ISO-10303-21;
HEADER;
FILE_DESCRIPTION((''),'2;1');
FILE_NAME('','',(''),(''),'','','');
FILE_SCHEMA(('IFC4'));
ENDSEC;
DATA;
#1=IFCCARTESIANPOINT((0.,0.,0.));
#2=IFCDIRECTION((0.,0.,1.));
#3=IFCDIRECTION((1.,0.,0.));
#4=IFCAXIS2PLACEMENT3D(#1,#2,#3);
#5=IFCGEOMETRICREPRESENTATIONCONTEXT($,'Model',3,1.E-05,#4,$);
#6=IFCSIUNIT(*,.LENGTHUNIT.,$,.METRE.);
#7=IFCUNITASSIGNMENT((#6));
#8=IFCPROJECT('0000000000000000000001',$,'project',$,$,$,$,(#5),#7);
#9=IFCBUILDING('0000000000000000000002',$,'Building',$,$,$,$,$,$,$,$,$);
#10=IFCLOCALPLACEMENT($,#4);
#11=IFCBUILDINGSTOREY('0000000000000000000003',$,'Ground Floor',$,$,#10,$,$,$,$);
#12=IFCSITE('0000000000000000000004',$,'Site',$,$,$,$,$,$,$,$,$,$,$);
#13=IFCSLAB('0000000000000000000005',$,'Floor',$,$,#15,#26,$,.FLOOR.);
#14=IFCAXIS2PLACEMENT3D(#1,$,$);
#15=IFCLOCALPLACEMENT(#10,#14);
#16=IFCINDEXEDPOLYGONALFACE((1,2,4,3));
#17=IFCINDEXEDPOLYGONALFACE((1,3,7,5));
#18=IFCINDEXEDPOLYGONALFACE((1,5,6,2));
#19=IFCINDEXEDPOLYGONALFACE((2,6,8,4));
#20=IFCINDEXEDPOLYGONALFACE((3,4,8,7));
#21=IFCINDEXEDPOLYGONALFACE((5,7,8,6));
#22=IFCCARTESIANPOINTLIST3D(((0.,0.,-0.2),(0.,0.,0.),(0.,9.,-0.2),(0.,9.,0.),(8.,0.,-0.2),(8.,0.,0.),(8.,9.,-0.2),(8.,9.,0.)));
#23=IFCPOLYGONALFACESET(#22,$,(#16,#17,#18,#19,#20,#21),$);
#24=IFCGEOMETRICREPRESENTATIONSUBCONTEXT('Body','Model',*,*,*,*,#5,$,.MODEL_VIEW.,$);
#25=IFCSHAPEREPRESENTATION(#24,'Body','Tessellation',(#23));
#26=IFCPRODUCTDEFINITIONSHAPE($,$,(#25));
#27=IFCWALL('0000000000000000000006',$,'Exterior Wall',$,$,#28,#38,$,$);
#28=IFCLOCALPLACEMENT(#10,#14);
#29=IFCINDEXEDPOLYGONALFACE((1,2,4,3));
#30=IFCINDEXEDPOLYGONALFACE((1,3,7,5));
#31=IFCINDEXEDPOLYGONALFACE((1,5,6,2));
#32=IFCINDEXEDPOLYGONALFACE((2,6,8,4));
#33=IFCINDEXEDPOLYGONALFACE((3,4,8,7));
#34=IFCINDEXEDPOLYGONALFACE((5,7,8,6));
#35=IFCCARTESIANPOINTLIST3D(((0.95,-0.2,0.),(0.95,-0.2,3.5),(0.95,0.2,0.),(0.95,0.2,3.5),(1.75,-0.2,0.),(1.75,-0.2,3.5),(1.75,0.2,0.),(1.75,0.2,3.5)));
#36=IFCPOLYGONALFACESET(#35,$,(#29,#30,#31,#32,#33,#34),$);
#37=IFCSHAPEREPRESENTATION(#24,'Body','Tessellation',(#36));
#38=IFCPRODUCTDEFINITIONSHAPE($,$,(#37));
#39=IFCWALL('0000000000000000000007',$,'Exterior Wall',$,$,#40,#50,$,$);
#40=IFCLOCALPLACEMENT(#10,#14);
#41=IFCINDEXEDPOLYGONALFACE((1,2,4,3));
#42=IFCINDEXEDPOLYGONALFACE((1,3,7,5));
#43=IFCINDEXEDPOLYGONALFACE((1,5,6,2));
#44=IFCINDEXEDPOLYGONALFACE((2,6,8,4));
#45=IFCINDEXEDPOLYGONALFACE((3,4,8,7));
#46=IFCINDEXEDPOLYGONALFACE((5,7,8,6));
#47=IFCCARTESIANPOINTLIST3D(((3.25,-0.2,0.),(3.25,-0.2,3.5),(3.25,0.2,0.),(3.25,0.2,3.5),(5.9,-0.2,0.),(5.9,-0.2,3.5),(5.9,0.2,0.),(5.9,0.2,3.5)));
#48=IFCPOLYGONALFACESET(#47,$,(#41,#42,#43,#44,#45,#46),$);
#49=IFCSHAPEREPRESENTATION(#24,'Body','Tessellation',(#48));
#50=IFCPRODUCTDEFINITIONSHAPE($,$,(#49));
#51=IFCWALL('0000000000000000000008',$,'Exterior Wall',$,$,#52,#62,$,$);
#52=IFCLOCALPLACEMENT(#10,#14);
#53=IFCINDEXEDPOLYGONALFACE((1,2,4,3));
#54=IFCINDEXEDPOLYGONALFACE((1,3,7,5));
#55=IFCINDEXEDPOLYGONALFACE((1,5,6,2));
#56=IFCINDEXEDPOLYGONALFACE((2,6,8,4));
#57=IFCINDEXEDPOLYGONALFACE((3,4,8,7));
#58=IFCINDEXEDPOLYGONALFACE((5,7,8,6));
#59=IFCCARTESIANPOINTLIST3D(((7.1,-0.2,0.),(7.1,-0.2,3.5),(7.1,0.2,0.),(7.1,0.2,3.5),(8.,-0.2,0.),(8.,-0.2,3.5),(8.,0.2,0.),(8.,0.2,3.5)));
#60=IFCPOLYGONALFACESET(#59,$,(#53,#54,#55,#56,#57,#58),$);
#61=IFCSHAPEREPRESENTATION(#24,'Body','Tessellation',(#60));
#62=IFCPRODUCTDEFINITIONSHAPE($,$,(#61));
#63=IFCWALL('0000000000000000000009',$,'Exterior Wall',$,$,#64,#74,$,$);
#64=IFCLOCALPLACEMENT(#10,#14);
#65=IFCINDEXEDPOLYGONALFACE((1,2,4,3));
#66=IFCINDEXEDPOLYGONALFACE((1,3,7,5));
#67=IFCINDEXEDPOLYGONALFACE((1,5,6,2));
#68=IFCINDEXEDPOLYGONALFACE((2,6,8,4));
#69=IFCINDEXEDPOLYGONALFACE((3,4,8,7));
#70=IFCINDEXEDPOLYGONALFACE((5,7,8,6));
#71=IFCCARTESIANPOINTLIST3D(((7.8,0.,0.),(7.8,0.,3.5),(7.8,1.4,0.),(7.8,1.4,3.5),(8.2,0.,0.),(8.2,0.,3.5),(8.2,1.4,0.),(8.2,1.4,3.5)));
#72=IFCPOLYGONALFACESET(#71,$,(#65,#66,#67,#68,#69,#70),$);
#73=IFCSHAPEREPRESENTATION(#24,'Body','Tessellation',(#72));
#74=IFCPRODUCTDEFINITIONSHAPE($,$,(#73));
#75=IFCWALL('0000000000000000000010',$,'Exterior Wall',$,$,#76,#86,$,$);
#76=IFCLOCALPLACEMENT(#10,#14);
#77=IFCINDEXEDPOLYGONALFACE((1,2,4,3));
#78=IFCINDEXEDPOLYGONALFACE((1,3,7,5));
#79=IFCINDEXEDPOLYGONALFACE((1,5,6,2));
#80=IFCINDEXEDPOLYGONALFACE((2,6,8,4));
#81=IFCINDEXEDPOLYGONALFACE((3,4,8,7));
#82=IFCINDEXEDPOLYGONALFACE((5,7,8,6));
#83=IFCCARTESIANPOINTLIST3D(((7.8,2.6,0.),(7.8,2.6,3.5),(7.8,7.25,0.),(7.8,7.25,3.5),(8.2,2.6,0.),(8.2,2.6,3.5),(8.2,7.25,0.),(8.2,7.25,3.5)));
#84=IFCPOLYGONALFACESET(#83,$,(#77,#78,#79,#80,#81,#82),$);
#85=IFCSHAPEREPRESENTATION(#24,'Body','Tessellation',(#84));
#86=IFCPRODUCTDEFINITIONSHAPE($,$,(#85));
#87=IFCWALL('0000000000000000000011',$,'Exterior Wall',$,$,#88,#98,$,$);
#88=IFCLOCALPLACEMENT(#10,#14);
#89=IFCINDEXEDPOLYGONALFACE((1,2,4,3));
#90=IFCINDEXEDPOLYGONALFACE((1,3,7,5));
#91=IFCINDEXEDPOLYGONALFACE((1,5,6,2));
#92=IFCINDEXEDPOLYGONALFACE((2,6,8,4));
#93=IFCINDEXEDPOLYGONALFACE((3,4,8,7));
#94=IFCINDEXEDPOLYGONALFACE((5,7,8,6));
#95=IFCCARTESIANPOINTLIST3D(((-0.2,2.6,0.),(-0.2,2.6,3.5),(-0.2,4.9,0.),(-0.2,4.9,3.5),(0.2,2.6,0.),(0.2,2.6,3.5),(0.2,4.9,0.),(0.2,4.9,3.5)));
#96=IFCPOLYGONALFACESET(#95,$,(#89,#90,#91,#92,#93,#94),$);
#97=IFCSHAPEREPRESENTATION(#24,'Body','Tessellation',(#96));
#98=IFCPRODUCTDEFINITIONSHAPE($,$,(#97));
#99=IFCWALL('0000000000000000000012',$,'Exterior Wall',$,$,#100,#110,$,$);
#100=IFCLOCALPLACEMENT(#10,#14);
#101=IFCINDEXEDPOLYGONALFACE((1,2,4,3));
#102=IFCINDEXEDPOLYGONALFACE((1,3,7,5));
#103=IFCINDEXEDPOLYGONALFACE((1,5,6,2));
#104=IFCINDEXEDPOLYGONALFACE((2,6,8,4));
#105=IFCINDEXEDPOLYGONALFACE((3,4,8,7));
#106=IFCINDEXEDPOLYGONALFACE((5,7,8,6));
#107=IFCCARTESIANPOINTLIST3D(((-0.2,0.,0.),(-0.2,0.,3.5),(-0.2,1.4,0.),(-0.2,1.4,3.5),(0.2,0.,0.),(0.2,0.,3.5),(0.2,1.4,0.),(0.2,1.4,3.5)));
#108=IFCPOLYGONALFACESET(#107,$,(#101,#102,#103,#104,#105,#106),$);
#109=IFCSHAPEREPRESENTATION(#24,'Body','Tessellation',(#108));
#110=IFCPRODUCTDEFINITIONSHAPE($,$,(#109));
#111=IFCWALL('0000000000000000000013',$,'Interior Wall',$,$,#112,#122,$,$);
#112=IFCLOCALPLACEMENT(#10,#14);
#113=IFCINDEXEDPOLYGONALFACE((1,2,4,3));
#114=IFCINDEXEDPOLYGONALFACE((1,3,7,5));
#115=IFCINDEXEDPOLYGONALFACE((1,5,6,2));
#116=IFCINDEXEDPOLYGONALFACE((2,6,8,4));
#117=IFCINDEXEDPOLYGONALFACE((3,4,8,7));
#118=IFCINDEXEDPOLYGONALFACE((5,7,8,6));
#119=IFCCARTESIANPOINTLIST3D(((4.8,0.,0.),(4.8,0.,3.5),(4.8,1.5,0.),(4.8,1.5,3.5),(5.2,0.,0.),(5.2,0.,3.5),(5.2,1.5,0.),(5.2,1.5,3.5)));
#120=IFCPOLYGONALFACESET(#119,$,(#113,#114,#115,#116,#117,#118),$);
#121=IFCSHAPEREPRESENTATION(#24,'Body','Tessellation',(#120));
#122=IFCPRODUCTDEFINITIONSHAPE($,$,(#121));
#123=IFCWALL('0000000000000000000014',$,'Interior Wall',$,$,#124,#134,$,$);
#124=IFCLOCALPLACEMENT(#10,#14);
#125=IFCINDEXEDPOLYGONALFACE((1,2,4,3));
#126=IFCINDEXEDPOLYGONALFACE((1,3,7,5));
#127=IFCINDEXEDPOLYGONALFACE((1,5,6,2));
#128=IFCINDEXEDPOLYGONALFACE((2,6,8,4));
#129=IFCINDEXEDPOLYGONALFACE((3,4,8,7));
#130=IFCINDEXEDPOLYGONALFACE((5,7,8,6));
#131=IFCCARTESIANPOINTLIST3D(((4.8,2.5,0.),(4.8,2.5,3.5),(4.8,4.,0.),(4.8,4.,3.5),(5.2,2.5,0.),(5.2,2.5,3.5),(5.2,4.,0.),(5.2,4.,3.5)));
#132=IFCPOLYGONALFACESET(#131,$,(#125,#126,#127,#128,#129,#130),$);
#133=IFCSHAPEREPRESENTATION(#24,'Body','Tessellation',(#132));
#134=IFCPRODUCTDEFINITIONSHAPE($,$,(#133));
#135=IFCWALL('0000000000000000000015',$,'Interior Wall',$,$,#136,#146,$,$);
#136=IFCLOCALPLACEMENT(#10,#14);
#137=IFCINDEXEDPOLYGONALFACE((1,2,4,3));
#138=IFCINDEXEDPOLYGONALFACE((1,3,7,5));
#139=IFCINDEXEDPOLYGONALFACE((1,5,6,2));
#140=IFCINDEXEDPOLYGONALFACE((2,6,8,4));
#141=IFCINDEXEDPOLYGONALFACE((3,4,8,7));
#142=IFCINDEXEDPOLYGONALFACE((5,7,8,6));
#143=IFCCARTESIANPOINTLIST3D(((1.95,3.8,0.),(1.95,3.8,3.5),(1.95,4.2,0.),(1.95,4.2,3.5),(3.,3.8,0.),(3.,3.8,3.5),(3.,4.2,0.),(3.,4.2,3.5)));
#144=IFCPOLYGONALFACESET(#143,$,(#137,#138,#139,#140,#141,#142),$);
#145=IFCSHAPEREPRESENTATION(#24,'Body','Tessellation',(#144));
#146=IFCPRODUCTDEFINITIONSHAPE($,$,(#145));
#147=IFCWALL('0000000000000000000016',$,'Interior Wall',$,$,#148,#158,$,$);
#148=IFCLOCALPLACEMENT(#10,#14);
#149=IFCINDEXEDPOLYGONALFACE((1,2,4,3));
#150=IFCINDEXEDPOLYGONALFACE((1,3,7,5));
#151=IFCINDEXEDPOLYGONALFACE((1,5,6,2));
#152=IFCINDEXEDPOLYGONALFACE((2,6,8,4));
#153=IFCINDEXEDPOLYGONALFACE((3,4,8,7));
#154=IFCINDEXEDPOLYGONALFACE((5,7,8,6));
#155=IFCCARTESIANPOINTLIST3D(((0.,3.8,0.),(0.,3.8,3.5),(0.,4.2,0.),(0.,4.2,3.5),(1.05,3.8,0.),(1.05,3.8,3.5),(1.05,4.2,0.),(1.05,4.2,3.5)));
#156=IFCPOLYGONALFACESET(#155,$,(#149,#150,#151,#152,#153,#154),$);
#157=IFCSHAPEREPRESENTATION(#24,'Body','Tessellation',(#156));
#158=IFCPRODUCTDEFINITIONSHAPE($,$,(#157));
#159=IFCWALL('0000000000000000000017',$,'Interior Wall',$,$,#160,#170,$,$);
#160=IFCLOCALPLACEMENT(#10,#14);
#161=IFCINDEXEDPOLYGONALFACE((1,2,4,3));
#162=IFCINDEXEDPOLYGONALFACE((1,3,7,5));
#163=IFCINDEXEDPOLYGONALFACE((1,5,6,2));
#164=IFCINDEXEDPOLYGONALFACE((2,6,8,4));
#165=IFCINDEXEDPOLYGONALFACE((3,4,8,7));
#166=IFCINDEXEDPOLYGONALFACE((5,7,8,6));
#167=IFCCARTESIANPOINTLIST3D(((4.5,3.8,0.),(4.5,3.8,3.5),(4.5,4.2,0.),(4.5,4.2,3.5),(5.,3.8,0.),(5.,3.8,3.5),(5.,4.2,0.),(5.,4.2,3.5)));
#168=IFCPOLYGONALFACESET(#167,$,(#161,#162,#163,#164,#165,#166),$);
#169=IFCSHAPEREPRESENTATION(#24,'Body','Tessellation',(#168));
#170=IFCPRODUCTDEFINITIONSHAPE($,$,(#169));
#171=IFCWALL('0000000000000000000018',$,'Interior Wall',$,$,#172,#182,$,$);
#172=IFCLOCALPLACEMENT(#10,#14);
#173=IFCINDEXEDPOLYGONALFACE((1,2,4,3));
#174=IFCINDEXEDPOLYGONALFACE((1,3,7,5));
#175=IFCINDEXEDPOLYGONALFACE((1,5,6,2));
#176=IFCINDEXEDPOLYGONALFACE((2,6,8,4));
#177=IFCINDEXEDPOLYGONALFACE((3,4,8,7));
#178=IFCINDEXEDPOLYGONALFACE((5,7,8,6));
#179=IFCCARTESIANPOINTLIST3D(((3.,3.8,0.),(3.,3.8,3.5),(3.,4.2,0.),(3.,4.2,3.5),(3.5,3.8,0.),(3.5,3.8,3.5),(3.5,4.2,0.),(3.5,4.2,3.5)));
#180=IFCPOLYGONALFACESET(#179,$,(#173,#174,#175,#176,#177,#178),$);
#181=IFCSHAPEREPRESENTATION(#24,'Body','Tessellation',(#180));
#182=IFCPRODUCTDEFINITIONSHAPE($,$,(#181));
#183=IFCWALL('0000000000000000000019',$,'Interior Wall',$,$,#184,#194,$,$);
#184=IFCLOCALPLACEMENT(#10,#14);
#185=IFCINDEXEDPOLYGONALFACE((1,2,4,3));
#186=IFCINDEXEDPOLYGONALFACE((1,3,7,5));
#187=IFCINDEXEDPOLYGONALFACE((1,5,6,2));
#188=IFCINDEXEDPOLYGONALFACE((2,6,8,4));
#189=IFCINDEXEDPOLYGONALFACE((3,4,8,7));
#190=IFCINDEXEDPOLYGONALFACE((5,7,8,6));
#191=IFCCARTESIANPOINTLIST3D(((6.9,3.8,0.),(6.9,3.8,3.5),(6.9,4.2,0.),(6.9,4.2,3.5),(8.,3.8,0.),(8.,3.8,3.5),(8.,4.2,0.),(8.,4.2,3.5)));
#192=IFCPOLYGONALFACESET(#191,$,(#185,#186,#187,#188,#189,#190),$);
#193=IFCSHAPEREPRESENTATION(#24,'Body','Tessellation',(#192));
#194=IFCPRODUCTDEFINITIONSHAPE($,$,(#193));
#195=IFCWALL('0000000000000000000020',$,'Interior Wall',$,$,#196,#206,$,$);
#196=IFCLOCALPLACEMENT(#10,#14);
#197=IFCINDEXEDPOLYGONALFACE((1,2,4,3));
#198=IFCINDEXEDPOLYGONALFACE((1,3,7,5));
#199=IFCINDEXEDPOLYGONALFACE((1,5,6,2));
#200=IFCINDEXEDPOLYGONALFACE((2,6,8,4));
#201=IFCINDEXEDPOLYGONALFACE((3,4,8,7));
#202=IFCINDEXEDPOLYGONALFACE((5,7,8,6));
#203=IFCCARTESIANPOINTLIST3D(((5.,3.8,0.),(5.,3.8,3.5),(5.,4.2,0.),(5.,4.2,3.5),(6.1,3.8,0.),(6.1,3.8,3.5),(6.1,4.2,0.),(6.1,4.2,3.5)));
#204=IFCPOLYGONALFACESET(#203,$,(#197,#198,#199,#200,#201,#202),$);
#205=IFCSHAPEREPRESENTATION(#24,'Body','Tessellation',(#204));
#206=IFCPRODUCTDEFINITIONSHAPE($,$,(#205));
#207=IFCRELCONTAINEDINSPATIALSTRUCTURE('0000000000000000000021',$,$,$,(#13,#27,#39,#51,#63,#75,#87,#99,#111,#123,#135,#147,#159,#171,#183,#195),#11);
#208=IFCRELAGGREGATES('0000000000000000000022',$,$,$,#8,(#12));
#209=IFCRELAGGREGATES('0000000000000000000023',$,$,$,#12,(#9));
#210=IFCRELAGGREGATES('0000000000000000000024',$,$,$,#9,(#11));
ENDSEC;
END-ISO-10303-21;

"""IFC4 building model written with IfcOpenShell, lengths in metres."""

from ifc_helpers import new_model, si_unit, frame, origin_with_axes, place, context, subcontext, project, spatial, indexed_curve, outline, extrude, element, save


model = new_model("IFC4")

# Units and contexts
model_context = context("Model", 3, precision=1e-05, world=origin_with_axes())
body_context = subcontext(model_context, "Body", "Model", "MODEL_VIEW")
ifc_project = project(units=[si_unit("LENGTHUNIT", "METRE")], contexts=[model_context])

# Site, building, storey
site = spatial("IfcSite", under=ifc_project, Name="Site")
building = spatial("IfcBuilding", under=site, Name="Building")
storey_placement = place(None, origin_with_axes())
storey = spatial("IfcBuildingStorey", under=building, at=storey_placement, Name="Ground Floor")

# Slab
slab_placement = place(storey_placement, frame((0.0, 0.0, -0.2), z_axis=(0.0, 0.0, 1.0), x_axis=(1.0, 0.0, 0.0)))
element("IfcSlab", 1, at=slab_placement, inside=storey, Name="Floor", PredefinedType="FLOOR", context=body_context, shape_type="SweptSolid", body=[
    extrude(outline(indexed_curve([(0.0, 0.0), (8.0, 0.0), (8.0, 9.0), (0.0, 9.0)])), None, (0.0, 0.0, 1.0), 0.2),
])

# Walls
wall_1_placement = place(storey_placement, frame((0.95, 0.0, 0.0), z_axis=(0.0, 0.0, 1.0), x_axis=(1.0, 0.0, 0.0)))
element("IfcWall", 2, at=wall_1_placement, inside=storey, Name="Exterior Wall", context=body_context, shape_type="SweptSolid", body=[
    extrude(outline(indexed_curve([(0.0, 0.0), (0.0, 0.4), (0.8, 0.4), (0.8, 0.0), (0.0, 0.0)], self_intersect=False)), frame((0.0, -0.2, 0.0), z_axis=(0.0, 0.0, 1.0), x_axis=(1.0, 0.0, 0.0)), (0.0, 0.0, 1.0), 3.5),
])
wall_2_placement = place(storey_placement, frame((3.25, 0.0, 0.0), z_axis=(0.0, 0.0, 1.0), x_axis=(1.0, 0.0, 0.0)))
element("IfcWall", 3, at=wall_2_placement, inside=storey, Name="Exterior Wall", context=body_context, shape_type="SweptSolid", body=[
    extrude(outline(indexed_curve([(0.0, 0.0), (0.0, 0.4), (2.65, 0.4), (2.65, 0.0), (0.0, 0.0)], self_intersect=False)), frame((0.0, -0.2, 0.0), z_axis=(0.0, 0.0, 1.0), x_axis=(1.0, 0.0, 0.0)), (0.0, 0.0, 1.0), 3.5),
])
wall_3_placement = place(storey_placement, frame((7.1, 0.0, 0.0), z_axis=(0.0, 0.0, 1.0), x_axis=(1.0, 0.0, 0.0)))
element("IfcWall", 4, at=wall_3_placement, inside=storey, Name="Exterior Wall", context=body_context, shape_type="SweptSolid", body=[
    extrude(outline(indexed_curve([(0.0, 0.0), (0.0, 0.4), (0.9, 0.4), (0.9, 0.0), (0.0, 0.0)], self_intersect=False)), frame((0.0, -0.2, 0.0), z_axis=(0.0, 0.0, 1.0), x_axis=(1.0, 0.0, 0.0)), (0.0, 0.0, 1.0), 3.5),
])
wall_4_placement = place(storey_placement, frame((8.0, 0.0, 0.0), z_axis=(0.0, 0.0, 1.0), x_axis=(0.0, 1.0, 0.0)))
element("IfcWall", 5, at=wall_4_placement, inside=storey, Name="Exterior Wall", context=body_context, shape_type="SweptSolid", body=[
    extrude(outline(indexed_curve([(0.0, 0.0), (0.0, 0.4), (1.4, 0.4), (1.4, 0.0), (0.0, 0.0)], self_intersect=False)), frame((0.0, -0.2, 0.0), z_axis=(0.0, 0.0, 1.0), x_axis=(1.0, 0.0, 0.0)), (0.0, 0.0, 1.0), 3.5),
])
wall_5_placement = place(storey_placement, frame((8.0, 2.6, 0.0), z_axis=(0.0, 0.0, 1.0), x_axis=(0.0, 1.0, 0.0)))
element("IfcWall", 6, at=wall_5_placement, inside=storey, Name="Exterior Wall", context=body_context, shape_type="SweptSolid", body=[
    extrude(outline(indexed_curve([(0.0, 0.0), (0.0, 0.4), (4.65, 0.4), (4.65, 0.0), (0.0, 0.0)], self_intersect=False)), frame((0.0, -0.2, 0.0), z_axis=(0.0, 0.0, 1.0), x_axis=(1.0, 0.0, 0.0)), (0.0, 0.0, 1.0), 3.5),
])
wall_6_placement = place(storey_placement, frame((0.0, 4.9, 0.0), z_axis=(0.0, 0.0, 1.0), x_axis=(0.0, -1.0, 0.0)))
element("IfcWall", 7, at=wall_6_placement, inside=storey, Name="Exterior Wall", context=body_context, shape_type="SweptSolid", body=[
    extrude(outline(indexed_curve([(0.0, 0.0), (0.0, 0.4), (2.3, 0.4), (2.3, 0.0), (0.0, 0.0)], self_intersect=False)), frame((0.0, -0.2, 0.0), z_axis=(0.0, 0.0, 1.0), x_axis=(1.0, 0.0, 0.0)), (0.0, 0.0, 1.0), 3.5),
])
wall_7_placement = place(storey_placement, frame((0.0, 1.4, 0.0), z_axis=(0.0, 0.0, 1.0), x_axis=(0.0, -1.0, 0.0)))
element("IfcWall", 8, at=wall_7_placement, inside=storey, Name="Exterior Wall", context=body_context, shape_type="SweptSolid", body=[
    extrude(outline(indexed_curve([(0.0, 0.0), (0.0, 0.4), (1.4, 0.4), (1.4, 0.0), (0.0, 0.0)], self_intersect=False)), frame((0.0, -0.2, 0.0), z_axis=(0.0, 0.0, 1.0), x_axis=(1.0, 0.0, 0.0)), (0.0, 0.0, 1.0), 3.5),
])
for number, where, z_axis, x_axis, name in (
    (9, (5.0, 0.0, 0.0), (0.0, 0.0, 1.0), (0.0, 1.0, 0.0), "Interior Wall"),
    (10, (5.0, 2.5, 0.0), (0.0, 0.0, 1.0), (0.0, 1.0, 0.0), "Interior Wall"),
):
    element("IfcWall", number, at=place(storey_placement, frame(where, z_axis=z_axis, x_axis=x_axis)), inside=storey, Name=name, context=body_context, shape_type="SweptSolid", body=[
        extrude(outline(indexed_curve([(0.0, 0.0), (0.0, 0.4), (1.5, 0.4), (1.5, 0.0), (0.0, 0.0)], self_intersect=False)), frame((0.0, -0.2, 0.0), z_axis=(0.0, 0.0, 1.0), x_axis=(1.0, 0.0, 0.0)), (0.0, 0.0, 1.0), 3.5),
    ])
for number, where, z_axis, x_axis, name in (
    (11, (3.0, 4.0, 0.0), (0.0, 0.0, 1.0), (-1.0, 0.0, 0.0), "Interior Wall"),
    (12, (1.05, 4.0, 0.0), (0.0, 0.0, 1.0), (-1.0, 0.0, 0.0), "Interior Wall"),
):
    element("IfcWall", number, at=place(storey_placement, frame(where, z_axis=z_axis, x_axis=x_axis)), inside=storey, Name=name, context=body_context, shape_type="SweptSolid", body=[
        extrude(outline(indexed_curve([(0.0, 0.0), (0.0, 0.4), (1.05, 0.4), (1.05, 0.0), (0.0, 0.0)], self_intersect=False)), frame((0.0, -0.2, 0.0), z_axis=(0.0, 0.0, 1.0), x_axis=(1.0, 0.0, 0.0)), (0.0, 0.0, 1.0), 3.5),
    ])
for number, where, z_axis, x_axis, name in (
    (13, (5.0, 4.0, 0.0), (0.0, 0.0, 1.0), (-1.0, 0.0, 0.0), "Interior Wall"),
    (14, (3.5, 4.0, 0.0), (0.0, 0.0, 1.0), (-1.0, 0.0, 0.0), "Interior Wall"),
):
    element("IfcWall", number, at=place(storey_placement, frame(where, z_axis=z_axis, x_axis=x_axis)), inside=storey, Name=name, context=body_context, shape_type="SweptSolid", body=[
        extrude(outline(indexed_curve([(0.0, 0.0), (0.0, 0.4), (0.5, 0.4), (0.5, 0.0), (0.0, 0.0)], self_intersect=False)), frame((0.0, -0.2, 0.0), z_axis=(0.0, 0.0, 1.0), x_axis=(1.0, 0.0, 0.0)), (0.0, 0.0, 1.0), 3.5),
    ])
for number, where, z_axis, x_axis, name in (
    (15, (8.0, 4.0, 0.0), (0.0, 0.0, 1.0), (-1.0, 0.0, 0.0), "Interior Wall"),
    (16, (6.1, 4.0, 0.0), (0.0, 0.0, 1.0), (-1.0, 0.0, 0.0), "Interior Wall"),
):
    element("IfcWall", number, at=place(storey_placement, frame(where, z_axis=z_axis, x_axis=x_axis)), inside=storey, Name=name, context=body_context, shape_type="SweptSolid", body=[
        extrude(outline(indexed_curve([(0.0, 0.0), (0.0, 0.4), (1.1, 0.4), (1.1, 0.0), (0.0, 0.0)], self_intersect=False)), frame((0.0, -0.2, 0.0), z_axis=(0.0, 0.0, 1.0), x_axis=(1.0, 0.0, 0.0)), (0.0, 0.0, 1.0), 3.5),
    ])

save(model, "model.ifc")
